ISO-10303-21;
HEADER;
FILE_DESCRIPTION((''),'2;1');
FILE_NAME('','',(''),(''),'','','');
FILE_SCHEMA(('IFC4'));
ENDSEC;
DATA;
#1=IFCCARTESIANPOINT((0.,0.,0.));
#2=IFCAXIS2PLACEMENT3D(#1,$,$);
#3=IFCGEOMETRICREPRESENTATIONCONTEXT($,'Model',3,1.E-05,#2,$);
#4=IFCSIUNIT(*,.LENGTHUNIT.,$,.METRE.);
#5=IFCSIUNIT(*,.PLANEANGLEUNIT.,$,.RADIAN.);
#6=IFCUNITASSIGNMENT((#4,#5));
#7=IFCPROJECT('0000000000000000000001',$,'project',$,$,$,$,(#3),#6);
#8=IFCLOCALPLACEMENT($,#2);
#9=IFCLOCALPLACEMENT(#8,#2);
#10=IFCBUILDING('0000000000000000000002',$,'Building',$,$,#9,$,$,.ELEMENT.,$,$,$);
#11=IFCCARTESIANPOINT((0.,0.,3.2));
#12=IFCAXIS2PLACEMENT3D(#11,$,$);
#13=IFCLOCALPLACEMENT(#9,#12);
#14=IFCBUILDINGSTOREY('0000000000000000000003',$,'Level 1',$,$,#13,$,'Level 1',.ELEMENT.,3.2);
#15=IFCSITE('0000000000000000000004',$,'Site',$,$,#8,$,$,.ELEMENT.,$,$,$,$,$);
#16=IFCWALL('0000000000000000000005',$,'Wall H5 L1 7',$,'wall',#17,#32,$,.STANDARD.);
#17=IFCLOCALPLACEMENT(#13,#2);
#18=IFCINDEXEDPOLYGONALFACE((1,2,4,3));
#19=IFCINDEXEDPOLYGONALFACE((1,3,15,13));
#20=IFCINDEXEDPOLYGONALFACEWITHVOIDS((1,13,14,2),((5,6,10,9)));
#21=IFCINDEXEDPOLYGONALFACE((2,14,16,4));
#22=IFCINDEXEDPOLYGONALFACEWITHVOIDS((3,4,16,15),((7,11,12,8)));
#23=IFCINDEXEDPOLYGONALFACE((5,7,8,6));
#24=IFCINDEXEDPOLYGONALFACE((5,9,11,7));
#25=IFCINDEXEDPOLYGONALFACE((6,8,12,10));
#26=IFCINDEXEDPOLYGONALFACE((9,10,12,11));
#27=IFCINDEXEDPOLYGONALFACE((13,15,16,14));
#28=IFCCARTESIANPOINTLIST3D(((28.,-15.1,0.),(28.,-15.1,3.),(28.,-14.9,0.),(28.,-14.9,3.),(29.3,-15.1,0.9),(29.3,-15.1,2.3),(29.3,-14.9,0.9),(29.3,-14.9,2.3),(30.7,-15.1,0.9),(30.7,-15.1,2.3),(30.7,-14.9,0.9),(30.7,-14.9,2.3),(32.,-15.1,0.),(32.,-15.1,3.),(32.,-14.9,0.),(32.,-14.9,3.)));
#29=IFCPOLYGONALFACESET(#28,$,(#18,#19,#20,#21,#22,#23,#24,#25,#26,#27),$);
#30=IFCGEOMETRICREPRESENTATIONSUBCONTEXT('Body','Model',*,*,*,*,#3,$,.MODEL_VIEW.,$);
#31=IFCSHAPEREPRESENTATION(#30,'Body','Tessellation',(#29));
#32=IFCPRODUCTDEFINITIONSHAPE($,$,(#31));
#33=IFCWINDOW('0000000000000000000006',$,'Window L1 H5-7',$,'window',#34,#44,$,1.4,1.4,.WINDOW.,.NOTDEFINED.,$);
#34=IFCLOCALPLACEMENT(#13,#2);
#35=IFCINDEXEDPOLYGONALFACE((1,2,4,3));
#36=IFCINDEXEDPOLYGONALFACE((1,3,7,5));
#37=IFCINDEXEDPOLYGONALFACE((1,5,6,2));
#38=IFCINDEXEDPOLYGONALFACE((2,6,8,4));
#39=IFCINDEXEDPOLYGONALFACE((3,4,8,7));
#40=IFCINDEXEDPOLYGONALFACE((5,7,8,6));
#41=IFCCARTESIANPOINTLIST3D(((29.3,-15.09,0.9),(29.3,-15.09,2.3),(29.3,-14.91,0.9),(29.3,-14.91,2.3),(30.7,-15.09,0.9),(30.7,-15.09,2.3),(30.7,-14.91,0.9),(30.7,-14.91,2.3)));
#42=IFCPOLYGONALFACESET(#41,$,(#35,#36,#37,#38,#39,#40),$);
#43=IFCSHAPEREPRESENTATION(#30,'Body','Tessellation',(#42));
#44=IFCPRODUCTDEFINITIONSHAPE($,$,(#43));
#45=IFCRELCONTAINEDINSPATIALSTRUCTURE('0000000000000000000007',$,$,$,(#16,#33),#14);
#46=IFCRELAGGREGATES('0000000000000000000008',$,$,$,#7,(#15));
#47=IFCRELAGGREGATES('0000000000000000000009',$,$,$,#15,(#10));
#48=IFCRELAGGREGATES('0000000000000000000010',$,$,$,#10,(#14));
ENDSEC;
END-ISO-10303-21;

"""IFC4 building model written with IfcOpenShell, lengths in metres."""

from ifc_helpers import new_model, si_unit, frame, frame_2d, origin, origin_2d, place, context, subcontext, project, spatial, rectangle, extrude, element, fill, save


model = new_model("IFC4")

# Units and contexts
model_context = context("Model", 3, precision=1e-05, world=origin())
body_context = subcontext(model_context, "Body", "Model", "MODEL_VIEW")
ifc_project = project(units=[si_unit("LENGTHUNIT", "METRE"), si_unit("PLANEANGLEUNIT", "RADIAN")], contexts=[model_context])

# Site, building, storey
site_placement = place(None, origin())
site = spatial("IfcSite", under=ifc_project, at=site_placement, Name="Site", CompositionType="ELEMENT")
building_placement = place(site_placement, origin())
building = spatial("IfcBuilding", under=site, at=building_placement, Name="Building", CompositionType="ELEMENT")
storey_placement = place(building_placement, frame((0.0, 0.0, 3.2)))
storey = spatial("IfcBuildingStorey", under=building, at=storey_placement, Name="Level 1", LongName="Level 1", CompositionType="ELEMENT", Elevation=3.2)

# Wall, opening, window
wall_1_placement = place(storey_placement, frame((28.0, -15.0, 0.0), z_axis=(0.0, 0.0, 1.0), x_axis=(1.0, 0.0, 0.0)))
wall_1 = element("IfcWall", 1, at=wall_1_placement, inside=storey, Name="Wall H5 L1 7", ObjectType="wall", PredefinedType="STANDARD", context=body_context, shape_type="SweptSolid", body=[
    extrude(rectangle(XDim=4.0, YDim=0.2, at=frame_2d((2.0, 0.0))), origin(), (0.0, 0.0, 1.0), 3.0),
])
opening_1_placement = place(storey_placement, frame((30.0, -15.0, 0.9), z_axis=(0.0, 0.0, 1.0), x_axis=(1.0, 0.0, 0.0)))
opening_1 = element("IfcOpeningElement", 2, at=opening_1_placement, cuts=wall_1, ObjectType="Opening", PredefinedType="OPENING", context=body_context, shape_type="SweptSolid", body=[
    extrude(rectangle(XDim=1.4, YDim=0.22, at=origin_2d()), origin(), (0.0, 0.0, 1.0), 1.4),
])
window_1_placement = place(storey_placement, frame((30.0, -15.0, 0.9), z_axis=(0.0, 0.0, 1.0), x_axis=(1.0, 0.0, 0.0)))
window_1 = element("IfcWindow", 3, at=window_1_placement, inside=storey, Name="Window L1 H5-7", ObjectType="window", OverallHeight=1.4, OverallWidth=1.4, PartitioningType="NOTDEFINED", PredefinedType="WINDOW", context=body_context, shape_type="SweptSolid", body=[
    extrude(rectangle(XDim=1.4, YDim=0.18, at=origin_2d()), origin(), (0.0, 0.0, 1.0), 1.4),
])
fill(opening_1, window_1)

save(model, "model.ifc")
